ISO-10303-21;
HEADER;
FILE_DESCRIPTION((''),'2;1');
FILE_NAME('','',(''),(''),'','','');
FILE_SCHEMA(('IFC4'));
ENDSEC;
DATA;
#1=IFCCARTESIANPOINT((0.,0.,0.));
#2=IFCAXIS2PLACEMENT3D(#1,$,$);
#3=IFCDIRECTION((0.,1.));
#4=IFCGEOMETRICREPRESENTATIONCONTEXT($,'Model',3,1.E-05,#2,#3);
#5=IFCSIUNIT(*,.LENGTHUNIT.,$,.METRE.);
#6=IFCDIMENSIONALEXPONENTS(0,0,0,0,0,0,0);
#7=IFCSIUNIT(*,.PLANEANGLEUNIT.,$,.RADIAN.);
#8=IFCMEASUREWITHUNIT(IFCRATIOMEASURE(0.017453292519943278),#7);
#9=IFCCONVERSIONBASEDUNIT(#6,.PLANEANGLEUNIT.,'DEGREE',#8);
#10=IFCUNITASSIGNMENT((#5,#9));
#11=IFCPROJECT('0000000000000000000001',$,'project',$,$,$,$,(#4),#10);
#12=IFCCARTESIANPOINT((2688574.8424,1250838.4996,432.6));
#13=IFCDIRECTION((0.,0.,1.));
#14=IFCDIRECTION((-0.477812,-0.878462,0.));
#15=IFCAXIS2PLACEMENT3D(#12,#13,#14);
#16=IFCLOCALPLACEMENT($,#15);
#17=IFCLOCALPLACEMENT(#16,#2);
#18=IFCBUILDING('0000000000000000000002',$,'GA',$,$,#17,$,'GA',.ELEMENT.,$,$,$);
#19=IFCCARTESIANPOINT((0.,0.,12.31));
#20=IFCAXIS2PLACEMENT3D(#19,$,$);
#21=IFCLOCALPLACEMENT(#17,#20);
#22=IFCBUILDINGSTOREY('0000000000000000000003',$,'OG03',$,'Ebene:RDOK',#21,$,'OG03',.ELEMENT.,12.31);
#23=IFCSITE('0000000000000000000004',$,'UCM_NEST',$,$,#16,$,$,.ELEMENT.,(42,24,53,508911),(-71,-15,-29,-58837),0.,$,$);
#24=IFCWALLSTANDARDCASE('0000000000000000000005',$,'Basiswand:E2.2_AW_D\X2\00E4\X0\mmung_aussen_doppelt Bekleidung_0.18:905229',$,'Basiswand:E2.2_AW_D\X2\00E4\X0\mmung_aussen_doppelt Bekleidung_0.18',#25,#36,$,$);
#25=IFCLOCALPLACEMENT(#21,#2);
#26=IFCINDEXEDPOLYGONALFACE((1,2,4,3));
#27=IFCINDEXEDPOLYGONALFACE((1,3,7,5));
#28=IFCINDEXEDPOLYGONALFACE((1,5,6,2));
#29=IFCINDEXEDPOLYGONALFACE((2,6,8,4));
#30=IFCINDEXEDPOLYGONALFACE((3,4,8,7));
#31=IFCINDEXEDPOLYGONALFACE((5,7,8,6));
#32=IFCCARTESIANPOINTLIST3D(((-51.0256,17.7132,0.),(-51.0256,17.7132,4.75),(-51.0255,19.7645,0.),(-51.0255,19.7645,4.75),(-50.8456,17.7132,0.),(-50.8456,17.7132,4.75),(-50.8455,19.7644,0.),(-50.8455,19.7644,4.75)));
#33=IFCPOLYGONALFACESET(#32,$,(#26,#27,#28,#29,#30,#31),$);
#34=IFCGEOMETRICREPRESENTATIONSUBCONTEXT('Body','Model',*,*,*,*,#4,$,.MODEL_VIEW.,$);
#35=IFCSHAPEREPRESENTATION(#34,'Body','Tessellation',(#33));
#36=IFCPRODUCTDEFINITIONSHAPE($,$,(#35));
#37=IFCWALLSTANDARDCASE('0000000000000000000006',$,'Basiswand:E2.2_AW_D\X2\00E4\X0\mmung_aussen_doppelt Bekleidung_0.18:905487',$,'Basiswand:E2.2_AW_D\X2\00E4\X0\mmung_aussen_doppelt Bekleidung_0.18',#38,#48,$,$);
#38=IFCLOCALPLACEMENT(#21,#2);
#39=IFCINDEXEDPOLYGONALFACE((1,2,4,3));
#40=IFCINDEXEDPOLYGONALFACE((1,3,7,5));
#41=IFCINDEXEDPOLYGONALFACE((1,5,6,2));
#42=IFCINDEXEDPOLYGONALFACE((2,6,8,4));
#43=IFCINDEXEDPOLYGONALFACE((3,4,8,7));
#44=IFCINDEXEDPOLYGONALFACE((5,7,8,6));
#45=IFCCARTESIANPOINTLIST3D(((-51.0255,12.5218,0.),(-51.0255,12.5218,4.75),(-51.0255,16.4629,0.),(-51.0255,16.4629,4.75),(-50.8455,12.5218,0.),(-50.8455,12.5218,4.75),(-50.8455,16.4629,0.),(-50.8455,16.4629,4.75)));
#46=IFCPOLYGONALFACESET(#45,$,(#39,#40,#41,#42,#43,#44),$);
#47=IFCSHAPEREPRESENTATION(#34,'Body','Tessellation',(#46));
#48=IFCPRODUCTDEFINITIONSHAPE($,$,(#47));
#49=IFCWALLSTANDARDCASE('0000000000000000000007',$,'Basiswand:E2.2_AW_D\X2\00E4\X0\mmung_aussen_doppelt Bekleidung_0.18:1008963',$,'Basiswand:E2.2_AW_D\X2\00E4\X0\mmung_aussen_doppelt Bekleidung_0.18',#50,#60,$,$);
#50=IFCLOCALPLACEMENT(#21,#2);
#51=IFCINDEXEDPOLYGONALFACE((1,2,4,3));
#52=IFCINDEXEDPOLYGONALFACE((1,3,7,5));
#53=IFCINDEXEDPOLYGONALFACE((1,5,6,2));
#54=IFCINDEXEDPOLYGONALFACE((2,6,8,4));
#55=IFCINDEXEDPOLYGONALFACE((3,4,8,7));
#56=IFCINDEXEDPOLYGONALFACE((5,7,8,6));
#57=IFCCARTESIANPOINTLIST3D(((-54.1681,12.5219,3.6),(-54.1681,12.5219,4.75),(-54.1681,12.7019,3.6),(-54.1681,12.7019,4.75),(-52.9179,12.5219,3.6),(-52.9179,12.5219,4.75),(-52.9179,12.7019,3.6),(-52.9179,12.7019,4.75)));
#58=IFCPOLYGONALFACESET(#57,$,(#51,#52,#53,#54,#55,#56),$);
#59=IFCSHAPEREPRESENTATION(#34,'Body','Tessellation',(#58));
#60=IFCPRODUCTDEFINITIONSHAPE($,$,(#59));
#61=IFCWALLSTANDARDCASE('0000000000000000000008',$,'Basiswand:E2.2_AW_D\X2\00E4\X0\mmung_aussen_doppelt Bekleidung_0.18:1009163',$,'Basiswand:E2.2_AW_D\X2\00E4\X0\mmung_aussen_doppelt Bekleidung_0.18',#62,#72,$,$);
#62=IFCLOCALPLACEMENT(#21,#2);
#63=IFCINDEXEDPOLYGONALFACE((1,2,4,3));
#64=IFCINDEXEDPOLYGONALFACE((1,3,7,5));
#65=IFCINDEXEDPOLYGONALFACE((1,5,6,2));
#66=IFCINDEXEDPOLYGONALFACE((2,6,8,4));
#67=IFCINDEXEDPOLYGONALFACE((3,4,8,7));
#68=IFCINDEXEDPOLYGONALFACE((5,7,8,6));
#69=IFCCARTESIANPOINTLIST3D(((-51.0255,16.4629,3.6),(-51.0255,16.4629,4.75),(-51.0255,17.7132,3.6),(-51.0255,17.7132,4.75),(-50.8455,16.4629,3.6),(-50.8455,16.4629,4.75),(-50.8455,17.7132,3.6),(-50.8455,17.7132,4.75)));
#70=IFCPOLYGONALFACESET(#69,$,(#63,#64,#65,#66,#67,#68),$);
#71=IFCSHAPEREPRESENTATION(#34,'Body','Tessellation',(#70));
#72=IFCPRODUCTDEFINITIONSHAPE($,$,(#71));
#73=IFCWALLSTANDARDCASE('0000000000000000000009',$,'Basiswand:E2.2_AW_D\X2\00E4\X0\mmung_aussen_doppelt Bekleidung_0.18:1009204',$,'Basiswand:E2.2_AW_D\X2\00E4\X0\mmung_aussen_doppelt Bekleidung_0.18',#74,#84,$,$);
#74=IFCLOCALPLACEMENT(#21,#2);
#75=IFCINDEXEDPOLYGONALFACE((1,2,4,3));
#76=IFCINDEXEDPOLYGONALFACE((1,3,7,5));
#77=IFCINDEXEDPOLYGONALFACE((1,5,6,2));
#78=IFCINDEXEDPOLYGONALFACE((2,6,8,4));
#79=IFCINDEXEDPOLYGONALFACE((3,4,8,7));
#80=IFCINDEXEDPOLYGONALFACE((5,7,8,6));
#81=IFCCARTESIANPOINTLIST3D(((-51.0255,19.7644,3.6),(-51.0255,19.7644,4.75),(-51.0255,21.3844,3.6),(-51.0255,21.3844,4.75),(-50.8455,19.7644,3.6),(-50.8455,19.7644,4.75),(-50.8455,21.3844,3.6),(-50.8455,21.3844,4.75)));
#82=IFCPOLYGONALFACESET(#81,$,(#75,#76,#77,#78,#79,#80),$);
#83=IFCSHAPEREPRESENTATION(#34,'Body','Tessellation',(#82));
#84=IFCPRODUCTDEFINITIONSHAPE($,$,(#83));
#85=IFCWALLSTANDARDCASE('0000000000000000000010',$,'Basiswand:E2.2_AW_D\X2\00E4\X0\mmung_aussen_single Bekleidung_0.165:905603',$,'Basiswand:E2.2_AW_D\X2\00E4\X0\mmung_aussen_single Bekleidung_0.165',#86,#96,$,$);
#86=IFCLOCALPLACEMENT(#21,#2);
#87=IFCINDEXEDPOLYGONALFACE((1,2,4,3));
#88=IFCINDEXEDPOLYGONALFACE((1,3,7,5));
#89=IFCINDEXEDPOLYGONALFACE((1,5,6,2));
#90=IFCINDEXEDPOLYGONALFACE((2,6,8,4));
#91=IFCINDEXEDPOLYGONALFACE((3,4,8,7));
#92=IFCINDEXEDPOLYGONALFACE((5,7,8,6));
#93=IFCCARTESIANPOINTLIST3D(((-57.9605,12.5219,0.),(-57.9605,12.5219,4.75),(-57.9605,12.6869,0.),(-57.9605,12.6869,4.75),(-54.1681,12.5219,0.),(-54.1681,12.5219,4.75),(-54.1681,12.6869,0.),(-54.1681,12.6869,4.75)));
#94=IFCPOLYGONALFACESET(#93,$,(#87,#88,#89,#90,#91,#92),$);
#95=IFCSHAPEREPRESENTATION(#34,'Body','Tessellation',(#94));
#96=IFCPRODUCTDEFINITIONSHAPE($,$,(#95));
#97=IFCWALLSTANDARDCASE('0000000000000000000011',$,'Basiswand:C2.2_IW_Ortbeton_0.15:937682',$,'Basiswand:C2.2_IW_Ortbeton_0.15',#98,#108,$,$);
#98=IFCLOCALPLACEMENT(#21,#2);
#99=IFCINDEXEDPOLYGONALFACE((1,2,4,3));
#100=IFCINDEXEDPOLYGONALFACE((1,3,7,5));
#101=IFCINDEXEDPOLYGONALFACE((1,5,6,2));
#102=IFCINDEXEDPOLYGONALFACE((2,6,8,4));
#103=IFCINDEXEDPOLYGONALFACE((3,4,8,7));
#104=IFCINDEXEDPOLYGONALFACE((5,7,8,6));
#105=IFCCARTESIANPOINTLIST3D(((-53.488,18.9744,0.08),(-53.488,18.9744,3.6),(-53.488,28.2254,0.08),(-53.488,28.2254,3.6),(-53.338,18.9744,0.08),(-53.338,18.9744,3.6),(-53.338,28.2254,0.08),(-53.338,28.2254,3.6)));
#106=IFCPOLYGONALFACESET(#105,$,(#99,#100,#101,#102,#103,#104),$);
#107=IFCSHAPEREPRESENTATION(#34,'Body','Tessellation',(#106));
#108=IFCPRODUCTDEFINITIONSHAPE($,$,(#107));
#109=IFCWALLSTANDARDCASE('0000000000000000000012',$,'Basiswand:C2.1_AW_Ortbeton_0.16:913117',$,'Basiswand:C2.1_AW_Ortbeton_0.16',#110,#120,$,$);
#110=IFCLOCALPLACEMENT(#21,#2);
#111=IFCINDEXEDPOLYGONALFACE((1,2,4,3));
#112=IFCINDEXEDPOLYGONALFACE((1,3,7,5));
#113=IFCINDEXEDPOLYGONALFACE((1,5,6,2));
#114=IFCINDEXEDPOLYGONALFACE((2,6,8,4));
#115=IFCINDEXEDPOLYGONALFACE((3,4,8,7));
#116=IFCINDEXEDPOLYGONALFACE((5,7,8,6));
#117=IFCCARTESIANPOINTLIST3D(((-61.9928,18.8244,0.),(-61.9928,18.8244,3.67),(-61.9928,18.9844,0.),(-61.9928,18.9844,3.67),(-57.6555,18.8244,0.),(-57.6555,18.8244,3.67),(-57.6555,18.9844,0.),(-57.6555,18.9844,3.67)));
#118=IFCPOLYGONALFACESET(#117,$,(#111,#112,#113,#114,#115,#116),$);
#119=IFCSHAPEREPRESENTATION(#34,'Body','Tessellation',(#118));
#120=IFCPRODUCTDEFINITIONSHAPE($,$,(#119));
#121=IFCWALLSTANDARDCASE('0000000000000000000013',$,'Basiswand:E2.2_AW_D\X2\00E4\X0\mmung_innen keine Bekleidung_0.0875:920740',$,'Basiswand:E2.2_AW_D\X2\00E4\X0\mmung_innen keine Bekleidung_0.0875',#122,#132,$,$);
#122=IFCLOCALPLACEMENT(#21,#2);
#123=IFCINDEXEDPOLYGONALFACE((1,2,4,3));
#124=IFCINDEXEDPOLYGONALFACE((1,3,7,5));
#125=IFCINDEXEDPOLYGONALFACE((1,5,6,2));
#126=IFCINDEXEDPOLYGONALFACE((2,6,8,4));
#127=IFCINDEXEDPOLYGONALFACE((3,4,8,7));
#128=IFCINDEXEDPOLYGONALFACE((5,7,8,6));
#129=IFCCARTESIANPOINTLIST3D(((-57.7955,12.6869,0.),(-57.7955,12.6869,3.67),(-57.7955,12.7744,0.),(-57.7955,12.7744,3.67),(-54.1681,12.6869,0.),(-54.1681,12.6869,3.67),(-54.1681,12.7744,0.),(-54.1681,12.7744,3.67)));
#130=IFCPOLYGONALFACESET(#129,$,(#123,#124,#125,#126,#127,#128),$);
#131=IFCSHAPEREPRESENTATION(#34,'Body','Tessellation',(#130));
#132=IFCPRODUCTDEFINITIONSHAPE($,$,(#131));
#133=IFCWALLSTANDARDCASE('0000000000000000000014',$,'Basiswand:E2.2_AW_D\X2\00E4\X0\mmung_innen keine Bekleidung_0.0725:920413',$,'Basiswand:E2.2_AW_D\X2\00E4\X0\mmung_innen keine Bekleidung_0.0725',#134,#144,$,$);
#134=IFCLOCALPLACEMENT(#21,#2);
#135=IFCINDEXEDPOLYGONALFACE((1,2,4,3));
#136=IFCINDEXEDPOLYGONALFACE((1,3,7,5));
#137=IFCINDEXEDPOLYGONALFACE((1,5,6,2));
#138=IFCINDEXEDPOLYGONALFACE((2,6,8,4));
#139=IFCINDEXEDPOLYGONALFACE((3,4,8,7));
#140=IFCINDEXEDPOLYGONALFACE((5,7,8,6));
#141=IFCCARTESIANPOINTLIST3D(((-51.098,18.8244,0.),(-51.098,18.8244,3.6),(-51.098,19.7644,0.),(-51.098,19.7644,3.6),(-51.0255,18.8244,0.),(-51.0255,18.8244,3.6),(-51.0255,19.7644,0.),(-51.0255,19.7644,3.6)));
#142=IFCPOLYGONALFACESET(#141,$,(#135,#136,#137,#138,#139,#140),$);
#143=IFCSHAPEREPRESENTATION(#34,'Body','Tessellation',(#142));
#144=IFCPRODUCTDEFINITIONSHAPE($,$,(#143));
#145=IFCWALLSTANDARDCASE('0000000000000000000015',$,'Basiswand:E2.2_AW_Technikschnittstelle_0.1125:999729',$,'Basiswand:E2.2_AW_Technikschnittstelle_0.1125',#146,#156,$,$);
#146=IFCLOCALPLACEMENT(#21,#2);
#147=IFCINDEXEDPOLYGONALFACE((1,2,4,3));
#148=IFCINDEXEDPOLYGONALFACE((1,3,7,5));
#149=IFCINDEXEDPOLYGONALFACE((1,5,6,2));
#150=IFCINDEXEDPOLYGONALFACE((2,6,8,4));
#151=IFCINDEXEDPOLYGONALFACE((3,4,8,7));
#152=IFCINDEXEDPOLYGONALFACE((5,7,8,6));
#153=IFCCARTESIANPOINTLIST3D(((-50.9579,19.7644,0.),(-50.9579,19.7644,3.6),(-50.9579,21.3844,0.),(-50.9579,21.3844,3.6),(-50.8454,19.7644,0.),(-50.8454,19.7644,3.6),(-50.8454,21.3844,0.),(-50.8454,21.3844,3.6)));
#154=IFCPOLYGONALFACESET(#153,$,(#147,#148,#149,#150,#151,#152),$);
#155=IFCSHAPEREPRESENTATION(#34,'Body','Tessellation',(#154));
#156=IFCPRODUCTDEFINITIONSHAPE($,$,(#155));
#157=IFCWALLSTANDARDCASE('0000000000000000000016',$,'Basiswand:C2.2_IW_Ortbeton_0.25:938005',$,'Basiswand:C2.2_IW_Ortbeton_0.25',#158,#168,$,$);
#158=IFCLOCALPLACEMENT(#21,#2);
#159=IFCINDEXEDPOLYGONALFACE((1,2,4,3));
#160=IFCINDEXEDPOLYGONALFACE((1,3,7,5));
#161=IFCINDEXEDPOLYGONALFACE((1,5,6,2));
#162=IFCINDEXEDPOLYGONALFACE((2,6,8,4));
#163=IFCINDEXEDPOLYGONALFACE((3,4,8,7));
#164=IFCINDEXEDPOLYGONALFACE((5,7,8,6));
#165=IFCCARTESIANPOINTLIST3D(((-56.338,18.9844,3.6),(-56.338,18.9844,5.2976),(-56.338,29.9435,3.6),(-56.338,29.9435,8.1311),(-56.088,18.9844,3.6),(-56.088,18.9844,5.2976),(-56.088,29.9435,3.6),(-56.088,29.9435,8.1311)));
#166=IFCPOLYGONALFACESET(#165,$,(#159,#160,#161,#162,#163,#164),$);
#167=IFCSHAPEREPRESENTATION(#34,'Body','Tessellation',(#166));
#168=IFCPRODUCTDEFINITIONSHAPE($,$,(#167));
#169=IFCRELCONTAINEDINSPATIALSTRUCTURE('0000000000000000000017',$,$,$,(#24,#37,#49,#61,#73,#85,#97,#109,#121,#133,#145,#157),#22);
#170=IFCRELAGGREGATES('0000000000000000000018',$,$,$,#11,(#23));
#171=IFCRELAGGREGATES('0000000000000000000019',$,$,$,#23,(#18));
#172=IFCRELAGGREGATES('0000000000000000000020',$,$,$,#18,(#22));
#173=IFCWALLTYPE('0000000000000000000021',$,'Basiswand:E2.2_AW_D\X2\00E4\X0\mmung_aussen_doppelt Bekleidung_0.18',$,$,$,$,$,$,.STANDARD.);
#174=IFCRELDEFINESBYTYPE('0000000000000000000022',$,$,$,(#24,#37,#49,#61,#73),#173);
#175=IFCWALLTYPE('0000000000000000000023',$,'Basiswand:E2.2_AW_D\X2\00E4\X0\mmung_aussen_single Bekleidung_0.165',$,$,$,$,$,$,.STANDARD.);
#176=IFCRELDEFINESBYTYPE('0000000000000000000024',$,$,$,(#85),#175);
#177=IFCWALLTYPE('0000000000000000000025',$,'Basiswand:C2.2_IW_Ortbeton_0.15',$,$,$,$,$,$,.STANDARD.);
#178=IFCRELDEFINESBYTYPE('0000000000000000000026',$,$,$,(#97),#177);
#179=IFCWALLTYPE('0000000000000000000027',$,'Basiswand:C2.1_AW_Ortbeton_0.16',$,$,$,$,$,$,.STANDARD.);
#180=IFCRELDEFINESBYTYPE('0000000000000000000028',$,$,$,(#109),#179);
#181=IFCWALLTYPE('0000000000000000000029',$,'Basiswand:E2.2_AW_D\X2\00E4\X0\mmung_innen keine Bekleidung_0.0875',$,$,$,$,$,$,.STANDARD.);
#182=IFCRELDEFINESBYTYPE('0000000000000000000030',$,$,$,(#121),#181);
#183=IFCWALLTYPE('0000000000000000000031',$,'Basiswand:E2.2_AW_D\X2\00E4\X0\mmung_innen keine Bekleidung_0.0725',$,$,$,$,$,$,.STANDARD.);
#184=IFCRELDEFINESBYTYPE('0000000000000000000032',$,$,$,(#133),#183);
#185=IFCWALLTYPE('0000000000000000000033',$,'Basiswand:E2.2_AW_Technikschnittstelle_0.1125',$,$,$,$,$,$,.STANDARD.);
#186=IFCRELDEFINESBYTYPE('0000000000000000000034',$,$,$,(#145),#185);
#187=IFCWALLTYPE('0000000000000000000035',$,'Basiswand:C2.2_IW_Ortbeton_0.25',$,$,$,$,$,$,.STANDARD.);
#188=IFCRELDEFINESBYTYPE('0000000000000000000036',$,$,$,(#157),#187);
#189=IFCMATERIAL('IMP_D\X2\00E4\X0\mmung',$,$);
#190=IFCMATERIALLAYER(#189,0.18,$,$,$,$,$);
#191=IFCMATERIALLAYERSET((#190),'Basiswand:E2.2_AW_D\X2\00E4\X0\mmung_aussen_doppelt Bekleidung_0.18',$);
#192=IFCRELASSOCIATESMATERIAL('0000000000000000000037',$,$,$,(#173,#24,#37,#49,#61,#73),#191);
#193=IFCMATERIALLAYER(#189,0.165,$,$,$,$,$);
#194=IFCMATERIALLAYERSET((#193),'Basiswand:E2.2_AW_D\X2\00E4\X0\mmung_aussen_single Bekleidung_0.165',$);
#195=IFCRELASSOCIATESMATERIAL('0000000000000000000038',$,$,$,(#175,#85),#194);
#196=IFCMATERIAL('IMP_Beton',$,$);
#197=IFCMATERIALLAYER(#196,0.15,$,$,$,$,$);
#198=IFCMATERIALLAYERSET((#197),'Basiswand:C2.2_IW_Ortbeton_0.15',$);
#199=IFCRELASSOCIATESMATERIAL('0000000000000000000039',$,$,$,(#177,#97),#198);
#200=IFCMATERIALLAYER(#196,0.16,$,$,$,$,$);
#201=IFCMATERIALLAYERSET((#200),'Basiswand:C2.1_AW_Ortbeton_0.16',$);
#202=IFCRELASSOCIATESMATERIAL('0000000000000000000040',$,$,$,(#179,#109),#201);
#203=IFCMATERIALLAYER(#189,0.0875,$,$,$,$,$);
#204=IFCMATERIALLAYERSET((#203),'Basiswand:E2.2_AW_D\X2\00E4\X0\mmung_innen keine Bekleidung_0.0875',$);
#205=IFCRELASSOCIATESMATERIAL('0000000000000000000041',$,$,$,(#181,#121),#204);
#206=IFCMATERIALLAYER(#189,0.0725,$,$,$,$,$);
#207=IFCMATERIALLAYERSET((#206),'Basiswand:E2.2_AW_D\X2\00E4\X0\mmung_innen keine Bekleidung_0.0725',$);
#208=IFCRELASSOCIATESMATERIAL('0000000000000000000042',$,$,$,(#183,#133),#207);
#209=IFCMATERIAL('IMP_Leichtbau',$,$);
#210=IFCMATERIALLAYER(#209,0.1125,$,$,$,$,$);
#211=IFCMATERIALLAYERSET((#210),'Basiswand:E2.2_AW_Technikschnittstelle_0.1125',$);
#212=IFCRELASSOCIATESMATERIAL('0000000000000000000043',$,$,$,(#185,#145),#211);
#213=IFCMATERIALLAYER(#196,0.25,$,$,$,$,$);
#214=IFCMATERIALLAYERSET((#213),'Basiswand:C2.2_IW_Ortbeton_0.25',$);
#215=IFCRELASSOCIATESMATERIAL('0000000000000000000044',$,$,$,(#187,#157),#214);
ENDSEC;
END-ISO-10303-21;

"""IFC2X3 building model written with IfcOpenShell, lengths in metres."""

from ifc_helpers import new_model, entity, si_unit, converted_unit, direction, frame, frame_2d, origin, place, context, subcontext, project, spatial, polyline, rectangle, extrude, clip, halfspace, bounded_halfspace, material, layer, layer_set, layer_usage, type_object, element, save


model = new_model("IFC2X3")

# Units and contexts
model_context = context("Model", 3, precision=1e-05, world=origin(), true_north=direction((0.0, 1.0)))
body_context = subcontext(model_context, "Body", "Model", "MODEL_VIEW")
ifc_project = project(units=[si_unit("LENGTHUNIT", "METRE"), converted_unit("PLANEANGLEUNIT", "DEGREE", entity("IfcRatioMeasure", 0.017453292519943278), si_unit("PLANEANGLEUNIT", "RADIAN"), dimensions=[0, 0, 0, 0, 0, 0, 0])], contexts=[model_context])

# Site, building, storey
site_placement = place(None, frame((2688574.8424, 1250838.4996, 432.6), z_axis=(0.0, 0.0, 1.0), x_axis=(-0.477812, -0.878462, 0.0)))
site = spatial("IfcSite", under=ifc_project, at=site_placement, Name="UCM_NEST", CompositionType="ELEMENT", RefLatitude=(42, 24, 53, 508911), RefLongitude=(-71, -15, -29, -58837), RefElevation=0.0)
building_placement = place(site_placement, origin())
building = spatial("IfcBuilding", under=site, at=building_placement, Name="GA", LongName="GA", CompositionType="ELEMENT")
storey_placement = place(building_placement, frame((0.0, 0.0, 12.31)))
storey = spatial("IfcBuildingStorey", under=building, at=storey_placement, Name="OG03", ObjectType="Ebene:RDOK", LongName="OG03", CompositionType="ELEMENT", Elevation=12.31)

# Walls
ifc_material_1 = material(Name="IMP_Dämmung")
ifc_layer_1 = layer(ifc_material_1, 0.18)
ifc_layer_set_1 = layer_set([ifc_layer_1], Name="Basiswand:E2.2_AW_Dämmung_aussen_doppelt Bekleidung_0.18")
ifc_layer_usage_1 = layer_usage(ifc_layer_set_1, "AXIS2", "NEGATIVE", 0.09)
wall_type_1 = type_object("IfcWallType", Name="Basiswand:E2.2_AW_Dämmung_aussen_doppelt Bekleidung_0.18", PredefinedType="STANDARD", material=ifc_layer_set_1)
wall_1_placement = place(storey_placement, frame((-50.9355, 19.7644, 0.0), z_axis=(0.0, 0.0, 1.0), x_axis=(-0.000045, -1.0, 0.0)))
element("IfcWallStandardCase", 1, at=wall_1_placement, inside=storey, type_object=wall_type_1, material=ifc_layer_usage_1, Name="Basiswand:E2.2_AW_Dämmung_aussen_doppelt Bekleidung_0.18:905229", ObjectType="Basiswand:E2.2_AW_Dämmung_aussen_doppelt Bekleidung_0.18", context=body_context, shape_type="SweptSolid", body=[
    extrude(rectangle(XDim=2.0513, YDim=0.18, at=frame_2d((1.0256, 0.0), x_axis=(-1.0, 0.0))), origin(), (0.0, 0.0, 1.0), 4.75),
])
wall_2_placement = place(storey_placement, frame((-50.9355, 16.4629, 0.0), z_axis=(0.0, 0.0, 1.0), x_axis=(0.0, -1.0, 0.0)))
element("IfcWallStandardCase", 2, at=wall_2_placement, inside=storey, type_object=wall_type_1, material=ifc_layer_usage_1, Name="Basiswand:E2.2_AW_Dämmung_aussen_doppelt Bekleidung_0.18:905487", ObjectType="Basiswand:E2.2_AW_Dämmung_aussen_doppelt Bekleidung_0.18", context=body_context, shape_type="SweptSolid", body=[
    extrude(rectangle(XDim=3.9411, YDim=0.18, at=frame_2d((1.9706, 0.0), x_axis=(-1.0, 0.0))), origin(), (0.0, 0.0, 1.0), 4.75),
])
wall_3_placement = place(storey_placement, frame((-54.1681, 12.6119, 3.6)))
element("IfcWallStandardCase", 3, at=wall_3_placement, inside=storey, type_object=wall_type_1, material=ifc_layer_usage_1, Name="Basiswand:E2.2_AW_Dämmung_aussen_doppelt Bekleidung_0.18:1008963", ObjectType="Basiswand:E2.2_AW_Dämmung_aussen_doppelt Bekleidung_0.18", context=body_context, shape_type="SweptSolid", body=[
    extrude(rectangle(XDim=1.2503, YDim=0.18, at=frame_2d((0.6251, 0.0), x_axis=(-1.0, 0.0))), origin(), (0.0, 0.0, 1.0), 1.15),
])
wall_4_placement = place(storey_placement, frame((-50.9355, 16.4629, 3.6), z_axis=(0.0, 0.0, 1.0), x_axis=(0.0, 1.0, 0.0)))
element("IfcWallStandardCase", 4, at=wall_4_placement, inside=storey, type_object=wall_type_1, material=ifc_layer_usage_1, Name="Basiswand:E2.2_AW_Dämmung_aussen_doppelt Bekleidung_0.18:1009163", ObjectType="Basiswand:E2.2_AW_Dämmung_aussen_doppelt Bekleidung_0.18", context=body_context, shape_type="SweptSolid", body=[
    extrude(rectangle(XDim=1.2503, YDim=0.18, at=frame_2d((0.6251, 0.0), x_axis=(-1.0, 0.0))), origin(), (0.0, 0.0, 1.0), 1.15),
])
wall_5_placement = place(storey_placement, frame((-50.9355, 19.7644, 3.6), z_axis=(0.0, 0.0, 1.0), x_axis=(0.0, 1.0, 0.0)))
element("IfcWallStandardCase", 5, at=wall_5_placement, inside=storey, type_object=wall_type_1, material=ifc_layer_usage_1, Name="Basiswand:E2.2_AW_Dämmung_aussen_doppelt Bekleidung_0.18:1009204", ObjectType="Basiswand:E2.2_AW_Dämmung_aussen_doppelt Bekleidung_0.18", context=body_context, shape_type="SweptSolid", body=[
    extrude(rectangle(XDim=1.62, YDim=0.18, at=frame_2d((0.81, 0.0), x_axis=(-1.0, 0.0))), origin(), (0.0, 0.0, 1.0), 1.15),
])
ifc_layer_2 = layer(ifc_material_1, 0.165)
ifc_layer_set_2 = layer_set([ifc_layer_2], Name="Basiswand:E2.2_AW_Dämmung_aussen_single Bekleidung_0.165")
ifc_layer_usage_2 = layer_usage(ifc_layer_set_2, "AXIS2", "NEGATIVE", 0.0825)
wall_type_2 = type_object("IfcWallType", Name="Basiswand:E2.2_AW_Dämmung_aussen_single Bekleidung_0.165", PredefinedType="STANDARD", material=ifc_layer_set_2)
wall_6_placement = place(storey_placement, frame((-54.1681, 12.6044, 0.0), z_axis=(0.0, 0.0, 1.0), x_axis=(-1.0, 0.0, 0.0)))
element("IfcWallStandardCase", 6, at=wall_6_placement, inside=storey, type_object=wall_type_2, material=ifc_layer_usage_2, Name="Basiswand:E2.2_AW_Dämmung_aussen_single Bekleidung_0.165:905603", ObjectType="Basiswand:E2.2_AW_Dämmung_aussen_single Bekleidung_0.165", context=body_context, shape_type="SweptSolid", body=[
    extrude(rectangle(XDim=3.7923, YDim=0.165, at=frame_2d((1.8962, 0.0), x_axis=(-1.0, 0.0))), origin(), (0.0, 0.0, 1.0), 4.75),
])

# Shared definitions
ifc_material_2 = material(Name="IMP_Beton")
ifc_layer_3 = layer(ifc_material_2, 0.15)
ifc_layer_set_3 = layer_set([ifc_layer_3], Name="Basiswand:C2.2_IW_Ortbeton_0.15")
ifc_layer_usage_3 = layer_usage(ifc_layer_set_3, "AXIS2", "NEGATIVE", 0.075)
wall_type_3 = type_object("IfcWallType", Name="Basiswand:C2.2_IW_Ortbeton_0.15", PredefinedType="STANDARD", material=ifc_layer_set_3)

# Wall
wall_7_placement = place(storey_placement, frame((-53.413, 18.9744, 0.08), z_axis=(0.0, 0.0, 1.0), x_axis=(0.0, 1.0, 0.0)))
element("IfcWallStandardCase", 7, at=wall_7_placement, inside=storey, type_object=wall_type_3, material=ifc_layer_usage_3, Name="Basiswand:C2.2_IW_Ortbeton_0.15:937682", ObjectType="Basiswand:C2.2_IW_Ortbeton_0.15", context=body_context, shape_type="Clipping", body=[
    clip(extrude(rectangle(XDim=9.251, YDim=0.15, at=frame_2d((4.6255, 0.0), x_axis=(-1.0, 0.0))), origin(), (0.0, 0.0, 1.0), 3.52), bounded_halfspace(frame((9.251, -0.075, 0.0), z_axis=(0.0, 0.0, 1.0), x_axis=(0.0, 1.0, 0.0)), True, frame((9.251, -0.075, 0.0), z_axis=(0.0, 0.0, 1.0), x_axis=(0.0, 1.0, 0.0)), polyline([(0.0, 0.0), (0.15, 0.0), (0.15, 9.251), (0.0, 9.251), (0.0, 0.151), (0.0, 0.15), (0.0, 0.0)]))),
])

# Walls
ifc_layer_4 = layer(ifc_material_2, 0.16)
ifc_layer_set_4 = layer_set([ifc_layer_4], Name="Basiswand:C2.1_AW_Ortbeton_0.16")
ifc_layer_usage_4 = layer_usage(ifc_layer_set_4, "AXIS2", "NEGATIVE", 0.08)
wall_type_4 = type_object("IfcWallType", Name="Basiswand:C2.1_AW_Ortbeton_0.16", PredefinedType="STANDARD", material=ifc_layer_set_4)
wall_8_placement = place(storey_placement, frame((-57.6555, 18.9044, 0.0), z_axis=(0.0, 0.0, 1.0), x_axis=(-1.0, 0.0, 0.0)))
element("IfcWallStandardCase", 8, at=wall_8_placement, inside=storey, type_object=wall_type_4, material=ifc_layer_usage_4, Name="Basiswand:C2.1_AW_Ortbeton_0.16:913117", ObjectType="Basiswand:C2.1_AW_Ortbeton_0.16", context=body_context, shape_type="SweptSolid", body=[
    extrude(rectangle(XDim=4.3373, YDim=0.16, at=frame_2d((2.1686, 0.0), x_axis=(-1.0, 0.0))), origin(), (0.0, 0.0, 1.0), 3.67),
])
ifc_layer_5 = layer(ifc_material_1, 0.0875)
ifc_layer_set_5 = layer_set([ifc_layer_5], Name="Basiswand:E2.2_AW_Dämmung_innen keine Bekleidung_0.0875")
ifc_layer_usage_5 = layer_usage(ifc_layer_set_5, "AXIS2", "NEGATIVE", 0.0437)
wall_type_5 = type_object("IfcWallType", Name="Basiswand:E2.2_AW_Dämmung_innen keine Bekleidung_0.0875", PredefinedType="STANDARD", material=ifc_layer_set_5)
wall_9_placement = place(storey_placement, frame((-54.1681, 12.7307, 0.0), z_axis=(0.0, 0.0, 1.0), x_axis=(-1.0, 0.0, 0.0)))
element("IfcWallStandardCase", 9, at=wall_9_placement, inside=storey, type_object=wall_type_5, material=ifc_layer_usage_5, Name="Basiswand:E2.2_AW_Dämmung_innen keine Bekleidung_0.0875:920740", ObjectType="Basiswand:E2.2_AW_Dämmung_innen keine Bekleidung_0.0875", context=body_context, shape_type="SweptSolid", body=[
    extrude(rectangle(XDim=3.6273, YDim=0.0875, at=frame_2d((1.8137, 0.0), x_axis=(-1.0, 0.0))), origin(), (0.0, 0.0, 1.0), 3.67),
])
ifc_layer_6 = layer(ifc_material_1, 0.0725)
ifc_layer_set_6 = layer_set([ifc_layer_6], Name="Basiswand:E2.2_AW_Dämmung_innen keine Bekleidung_0.0725")
ifc_layer_usage_6 = layer_usage(ifc_layer_set_6, "AXIS2", "NEGATIVE", 0.0362)
wall_type_6 = type_object("IfcWallType", Name="Basiswand:E2.2_AW_Dämmung_innen keine Bekleidung_0.0725", PredefinedType="STANDARD", material=ifc_layer_set_6)
wall_10_placement = place(storey_placement, frame((-51.0617, 19.7644, 0.0), z_axis=(0.0, 0.0, 1.0), x_axis=(0.0, -1.0, 0.0)))
element("IfcWallStandardCase", 10, at=wall_10_placement, inside=storey, type_object=wall_type_6, material=ifc_layer_usage_6, Name="Basiswand:E2.2_AW_Dämmung_innen keine Bekleidung_0.0725:920413", ObjectType="Basiswand:E2.2_AW_Dämmung_innen keine Bekleidung_0.0725", context=body_context, shape_type="SweptSolid", body=[
    extrude(rectangle(XDim=0.94, YDim=0.0725, at=frame_2d((0.47, 0.0), x_axis=(-1.0, 0.0))), origin(), (0.0, 0.0, 1.0), 3.6),
])
ifc_material_3 = material(Name="IMP_Leichtbau")
ifc_layer_7 = layer(ifc_material_3, 0.1125)
ifc_layer_set_7 = layer_set([ifc_layer_7], Name="Basiswand:E2.2_AW_Technikschnittstelle_0.1125")
ifc_layer_usage_7 = layer_usage(ifc_layer_set_7, "AXIS2", "NEGATIVE", 0.0562)
wall_type_7 = type_object("IfcWallType", Name="Basiswand:E2.2_AW_Technikschnittstelle_0.1125", PredefinedType="STANDARD", material=ifc_layer_set_7)
wall_11_placement = place(storey_placement, frame((-50.9017, 19.7644, 0.0), z_axis=(0.0, 0.0, 1.0), x_axis=(0.0, 1.0, 0.0)))
element("IfcWallStandardCase", 11, at=wall_11_placement, inside=storey, type_object=wall_type_7, material=ifc_layer_usage_7, Name="Basiswand:E2.2_AW_Technikschnittstelle_0.1125:999729", ObjectType="Basiswand:E2.2_AW_Technikschnittstelle_0.1125", context=body_context, shape_type="SweptSolid", body=[
    extrude(rectangle(XDim=1.62, YDim=0.1125, at=frame_2d((0.81, 0.0), x_axis=(-1.0, 0.0))), origin(), (0.0, 0.0, 1.0), 3.6),
])
ifc_layer_8 = layer(ifc_material_2, 0.25)
ifc_layer_set_8 = layer_set([ifc_layer_8], Name="Basiswand:C2.2_IW_Ortbeton_0.25")
ifc_layer_usage_8 = layer_usage(ifc_layer_set_8, "AXIS2", "NEGATIVE", 0.125)
wall_type_8 = type_object("IfcWallType", Name="Basiswand:C2.2_IW_Ortbeton_0.25", PredefinedType="STANDARD", material=ifc_layer_set_8)
wall_12_placement = place(storey_placement, frame((-56.213, 18.9844, 3.6), z_axis=(0.0, 0.0, 1.0), x_axis=(0.0, 1.0, 0.0)))
element("IfcWallStandardCase", 12, at=wall_12_placement, inside=storey, type_object=wall_type_8, material=ifc_layer_usage_8, Name="Basiswand:C2.2_IW_Ortbeton_0.25:938005", ObjectType="Basiswand:C2.2_IW_Ortbeton_0.25", context=body_context, shape_type="Clipping", body=[
    clip(extrude(rectangle(XDim=10.959, YDim=0.25, at=frame_2d((5.4795, 0.0), x_axis=(-1.0, 0.0))), origin(), (0.0, 0.0, 1.0), 4.5311), halfspace(frame((0.0, -0.125, 1.6976), z_axis=(-0.250322, 0.0, 0.968163), x_axis=(0.0, 1.0, 0.0)), False)),
])

save(model, "model.ifc")
